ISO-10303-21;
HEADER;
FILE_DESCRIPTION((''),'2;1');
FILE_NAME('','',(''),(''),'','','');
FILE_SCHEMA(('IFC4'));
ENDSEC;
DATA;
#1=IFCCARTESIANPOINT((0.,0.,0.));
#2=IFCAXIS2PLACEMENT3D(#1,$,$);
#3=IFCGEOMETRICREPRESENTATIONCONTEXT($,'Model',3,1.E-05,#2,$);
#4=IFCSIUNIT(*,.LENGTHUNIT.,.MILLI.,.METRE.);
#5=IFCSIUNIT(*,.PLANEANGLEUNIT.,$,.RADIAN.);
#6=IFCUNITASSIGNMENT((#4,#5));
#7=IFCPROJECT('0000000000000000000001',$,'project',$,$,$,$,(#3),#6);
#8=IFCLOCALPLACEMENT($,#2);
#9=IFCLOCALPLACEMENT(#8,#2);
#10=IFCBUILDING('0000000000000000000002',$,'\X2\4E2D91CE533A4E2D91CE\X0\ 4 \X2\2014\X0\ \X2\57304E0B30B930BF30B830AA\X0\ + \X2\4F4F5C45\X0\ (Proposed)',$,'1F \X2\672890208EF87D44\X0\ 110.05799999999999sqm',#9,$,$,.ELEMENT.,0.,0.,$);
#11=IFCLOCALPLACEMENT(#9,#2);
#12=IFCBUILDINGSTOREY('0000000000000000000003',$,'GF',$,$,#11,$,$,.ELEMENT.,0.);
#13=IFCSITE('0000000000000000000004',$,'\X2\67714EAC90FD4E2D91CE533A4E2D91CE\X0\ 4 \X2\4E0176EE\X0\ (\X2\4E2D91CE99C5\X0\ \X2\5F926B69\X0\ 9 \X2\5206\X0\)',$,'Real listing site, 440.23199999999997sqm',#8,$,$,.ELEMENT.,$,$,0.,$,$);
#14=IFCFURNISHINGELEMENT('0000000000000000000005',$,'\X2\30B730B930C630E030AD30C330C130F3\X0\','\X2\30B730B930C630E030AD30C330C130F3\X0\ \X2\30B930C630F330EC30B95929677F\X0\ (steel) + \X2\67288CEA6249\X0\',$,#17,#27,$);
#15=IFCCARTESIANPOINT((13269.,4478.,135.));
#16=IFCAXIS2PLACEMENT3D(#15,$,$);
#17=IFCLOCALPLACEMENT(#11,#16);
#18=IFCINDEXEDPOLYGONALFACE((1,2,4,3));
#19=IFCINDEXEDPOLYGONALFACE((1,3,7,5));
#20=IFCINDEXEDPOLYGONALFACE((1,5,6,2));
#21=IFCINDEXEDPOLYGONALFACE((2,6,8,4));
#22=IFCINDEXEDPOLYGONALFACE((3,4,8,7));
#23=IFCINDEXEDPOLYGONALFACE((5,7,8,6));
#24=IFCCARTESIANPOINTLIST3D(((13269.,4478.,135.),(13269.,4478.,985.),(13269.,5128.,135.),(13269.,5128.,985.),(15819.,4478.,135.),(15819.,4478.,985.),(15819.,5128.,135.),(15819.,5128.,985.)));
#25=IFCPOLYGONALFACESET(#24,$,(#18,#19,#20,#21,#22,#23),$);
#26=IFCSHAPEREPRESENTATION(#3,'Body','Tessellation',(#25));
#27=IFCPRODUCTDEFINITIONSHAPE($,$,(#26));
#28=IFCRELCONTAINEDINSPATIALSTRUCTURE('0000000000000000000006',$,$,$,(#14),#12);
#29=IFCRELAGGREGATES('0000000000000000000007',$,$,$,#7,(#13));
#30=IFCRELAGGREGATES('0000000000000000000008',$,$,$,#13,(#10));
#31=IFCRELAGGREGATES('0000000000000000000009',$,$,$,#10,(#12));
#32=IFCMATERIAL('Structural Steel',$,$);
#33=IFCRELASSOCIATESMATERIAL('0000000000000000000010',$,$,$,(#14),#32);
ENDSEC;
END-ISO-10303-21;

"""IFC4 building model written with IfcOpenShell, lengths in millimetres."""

from ifc_helpers import new_model, si_unit, frame, frame_2d, origin, place, context, project, spatial, rectangle, extrude, material, element, save


model = new_model("IFC4")

# Units and contexts
model_context = context("Model", 3, precision=1e-05, world=origin())
ifc_project = project(units=[si_unit("LENGTHUNIT", "METRE", prefix="MILLI"), si_unit("PLANEANGLEUNIT", "RADIAN")], contexts=[model_context])

# Site, building, storey
site_placement = place(None, origin())
site = spatial("IfcSite", under=ifc_project, at=site_placement, Name="東京都中野区中野 4 丁目 (中野駅 徒歩 9 分)", ObjectType="Real listing site, 440.23199999999997sqm", CompositionType="ELEMENT", RefElevation=0.0)
building_placement = place(site_placement, origin())
building = spatial("IfcBuilding", under=site, at=building_placement, Name="中野区中野 4 — 地下スタジオ + 住居 (Proposed)", ObjectType="1F 木造軸組 110.05799999999999sqm", CompositionType="ELEMENT", ElevationOfRefHeight=0.0, ElevationOfTerrain=0.0)
storey_placement = place(building_placement, origin())
storey = spatial("IfcBuildingStorey", under=building, at=storey_placement, Name="GF", CompositionType="ELEMENT", Elevation=0.0)

# Furnishing element
ifc_material_1 = material(Name="Structural Steel")
furnishing_1_placement = place(storey_placement, frame((13269.0, 4478.0, 135.0)))
element("IfcFurnishingElement", 1, at=furnishing_1_placement, inside=storey, material=ifc_material_1, Name="システムキッチン", Description="システムキッチン ステンレス天板 (steel) + 木質扉", context=model_context, shape_type="SweptSolid", body=[
    extrude(rectangle(XDim=2550.0, YDim=650.0, at=frame_2d((1275.0, 325.0))), frame((13269.0, 4478.0, 135.0)), (0.0, 0.0, 1.0), 850.0),
])

save(model, "model.ifc")
